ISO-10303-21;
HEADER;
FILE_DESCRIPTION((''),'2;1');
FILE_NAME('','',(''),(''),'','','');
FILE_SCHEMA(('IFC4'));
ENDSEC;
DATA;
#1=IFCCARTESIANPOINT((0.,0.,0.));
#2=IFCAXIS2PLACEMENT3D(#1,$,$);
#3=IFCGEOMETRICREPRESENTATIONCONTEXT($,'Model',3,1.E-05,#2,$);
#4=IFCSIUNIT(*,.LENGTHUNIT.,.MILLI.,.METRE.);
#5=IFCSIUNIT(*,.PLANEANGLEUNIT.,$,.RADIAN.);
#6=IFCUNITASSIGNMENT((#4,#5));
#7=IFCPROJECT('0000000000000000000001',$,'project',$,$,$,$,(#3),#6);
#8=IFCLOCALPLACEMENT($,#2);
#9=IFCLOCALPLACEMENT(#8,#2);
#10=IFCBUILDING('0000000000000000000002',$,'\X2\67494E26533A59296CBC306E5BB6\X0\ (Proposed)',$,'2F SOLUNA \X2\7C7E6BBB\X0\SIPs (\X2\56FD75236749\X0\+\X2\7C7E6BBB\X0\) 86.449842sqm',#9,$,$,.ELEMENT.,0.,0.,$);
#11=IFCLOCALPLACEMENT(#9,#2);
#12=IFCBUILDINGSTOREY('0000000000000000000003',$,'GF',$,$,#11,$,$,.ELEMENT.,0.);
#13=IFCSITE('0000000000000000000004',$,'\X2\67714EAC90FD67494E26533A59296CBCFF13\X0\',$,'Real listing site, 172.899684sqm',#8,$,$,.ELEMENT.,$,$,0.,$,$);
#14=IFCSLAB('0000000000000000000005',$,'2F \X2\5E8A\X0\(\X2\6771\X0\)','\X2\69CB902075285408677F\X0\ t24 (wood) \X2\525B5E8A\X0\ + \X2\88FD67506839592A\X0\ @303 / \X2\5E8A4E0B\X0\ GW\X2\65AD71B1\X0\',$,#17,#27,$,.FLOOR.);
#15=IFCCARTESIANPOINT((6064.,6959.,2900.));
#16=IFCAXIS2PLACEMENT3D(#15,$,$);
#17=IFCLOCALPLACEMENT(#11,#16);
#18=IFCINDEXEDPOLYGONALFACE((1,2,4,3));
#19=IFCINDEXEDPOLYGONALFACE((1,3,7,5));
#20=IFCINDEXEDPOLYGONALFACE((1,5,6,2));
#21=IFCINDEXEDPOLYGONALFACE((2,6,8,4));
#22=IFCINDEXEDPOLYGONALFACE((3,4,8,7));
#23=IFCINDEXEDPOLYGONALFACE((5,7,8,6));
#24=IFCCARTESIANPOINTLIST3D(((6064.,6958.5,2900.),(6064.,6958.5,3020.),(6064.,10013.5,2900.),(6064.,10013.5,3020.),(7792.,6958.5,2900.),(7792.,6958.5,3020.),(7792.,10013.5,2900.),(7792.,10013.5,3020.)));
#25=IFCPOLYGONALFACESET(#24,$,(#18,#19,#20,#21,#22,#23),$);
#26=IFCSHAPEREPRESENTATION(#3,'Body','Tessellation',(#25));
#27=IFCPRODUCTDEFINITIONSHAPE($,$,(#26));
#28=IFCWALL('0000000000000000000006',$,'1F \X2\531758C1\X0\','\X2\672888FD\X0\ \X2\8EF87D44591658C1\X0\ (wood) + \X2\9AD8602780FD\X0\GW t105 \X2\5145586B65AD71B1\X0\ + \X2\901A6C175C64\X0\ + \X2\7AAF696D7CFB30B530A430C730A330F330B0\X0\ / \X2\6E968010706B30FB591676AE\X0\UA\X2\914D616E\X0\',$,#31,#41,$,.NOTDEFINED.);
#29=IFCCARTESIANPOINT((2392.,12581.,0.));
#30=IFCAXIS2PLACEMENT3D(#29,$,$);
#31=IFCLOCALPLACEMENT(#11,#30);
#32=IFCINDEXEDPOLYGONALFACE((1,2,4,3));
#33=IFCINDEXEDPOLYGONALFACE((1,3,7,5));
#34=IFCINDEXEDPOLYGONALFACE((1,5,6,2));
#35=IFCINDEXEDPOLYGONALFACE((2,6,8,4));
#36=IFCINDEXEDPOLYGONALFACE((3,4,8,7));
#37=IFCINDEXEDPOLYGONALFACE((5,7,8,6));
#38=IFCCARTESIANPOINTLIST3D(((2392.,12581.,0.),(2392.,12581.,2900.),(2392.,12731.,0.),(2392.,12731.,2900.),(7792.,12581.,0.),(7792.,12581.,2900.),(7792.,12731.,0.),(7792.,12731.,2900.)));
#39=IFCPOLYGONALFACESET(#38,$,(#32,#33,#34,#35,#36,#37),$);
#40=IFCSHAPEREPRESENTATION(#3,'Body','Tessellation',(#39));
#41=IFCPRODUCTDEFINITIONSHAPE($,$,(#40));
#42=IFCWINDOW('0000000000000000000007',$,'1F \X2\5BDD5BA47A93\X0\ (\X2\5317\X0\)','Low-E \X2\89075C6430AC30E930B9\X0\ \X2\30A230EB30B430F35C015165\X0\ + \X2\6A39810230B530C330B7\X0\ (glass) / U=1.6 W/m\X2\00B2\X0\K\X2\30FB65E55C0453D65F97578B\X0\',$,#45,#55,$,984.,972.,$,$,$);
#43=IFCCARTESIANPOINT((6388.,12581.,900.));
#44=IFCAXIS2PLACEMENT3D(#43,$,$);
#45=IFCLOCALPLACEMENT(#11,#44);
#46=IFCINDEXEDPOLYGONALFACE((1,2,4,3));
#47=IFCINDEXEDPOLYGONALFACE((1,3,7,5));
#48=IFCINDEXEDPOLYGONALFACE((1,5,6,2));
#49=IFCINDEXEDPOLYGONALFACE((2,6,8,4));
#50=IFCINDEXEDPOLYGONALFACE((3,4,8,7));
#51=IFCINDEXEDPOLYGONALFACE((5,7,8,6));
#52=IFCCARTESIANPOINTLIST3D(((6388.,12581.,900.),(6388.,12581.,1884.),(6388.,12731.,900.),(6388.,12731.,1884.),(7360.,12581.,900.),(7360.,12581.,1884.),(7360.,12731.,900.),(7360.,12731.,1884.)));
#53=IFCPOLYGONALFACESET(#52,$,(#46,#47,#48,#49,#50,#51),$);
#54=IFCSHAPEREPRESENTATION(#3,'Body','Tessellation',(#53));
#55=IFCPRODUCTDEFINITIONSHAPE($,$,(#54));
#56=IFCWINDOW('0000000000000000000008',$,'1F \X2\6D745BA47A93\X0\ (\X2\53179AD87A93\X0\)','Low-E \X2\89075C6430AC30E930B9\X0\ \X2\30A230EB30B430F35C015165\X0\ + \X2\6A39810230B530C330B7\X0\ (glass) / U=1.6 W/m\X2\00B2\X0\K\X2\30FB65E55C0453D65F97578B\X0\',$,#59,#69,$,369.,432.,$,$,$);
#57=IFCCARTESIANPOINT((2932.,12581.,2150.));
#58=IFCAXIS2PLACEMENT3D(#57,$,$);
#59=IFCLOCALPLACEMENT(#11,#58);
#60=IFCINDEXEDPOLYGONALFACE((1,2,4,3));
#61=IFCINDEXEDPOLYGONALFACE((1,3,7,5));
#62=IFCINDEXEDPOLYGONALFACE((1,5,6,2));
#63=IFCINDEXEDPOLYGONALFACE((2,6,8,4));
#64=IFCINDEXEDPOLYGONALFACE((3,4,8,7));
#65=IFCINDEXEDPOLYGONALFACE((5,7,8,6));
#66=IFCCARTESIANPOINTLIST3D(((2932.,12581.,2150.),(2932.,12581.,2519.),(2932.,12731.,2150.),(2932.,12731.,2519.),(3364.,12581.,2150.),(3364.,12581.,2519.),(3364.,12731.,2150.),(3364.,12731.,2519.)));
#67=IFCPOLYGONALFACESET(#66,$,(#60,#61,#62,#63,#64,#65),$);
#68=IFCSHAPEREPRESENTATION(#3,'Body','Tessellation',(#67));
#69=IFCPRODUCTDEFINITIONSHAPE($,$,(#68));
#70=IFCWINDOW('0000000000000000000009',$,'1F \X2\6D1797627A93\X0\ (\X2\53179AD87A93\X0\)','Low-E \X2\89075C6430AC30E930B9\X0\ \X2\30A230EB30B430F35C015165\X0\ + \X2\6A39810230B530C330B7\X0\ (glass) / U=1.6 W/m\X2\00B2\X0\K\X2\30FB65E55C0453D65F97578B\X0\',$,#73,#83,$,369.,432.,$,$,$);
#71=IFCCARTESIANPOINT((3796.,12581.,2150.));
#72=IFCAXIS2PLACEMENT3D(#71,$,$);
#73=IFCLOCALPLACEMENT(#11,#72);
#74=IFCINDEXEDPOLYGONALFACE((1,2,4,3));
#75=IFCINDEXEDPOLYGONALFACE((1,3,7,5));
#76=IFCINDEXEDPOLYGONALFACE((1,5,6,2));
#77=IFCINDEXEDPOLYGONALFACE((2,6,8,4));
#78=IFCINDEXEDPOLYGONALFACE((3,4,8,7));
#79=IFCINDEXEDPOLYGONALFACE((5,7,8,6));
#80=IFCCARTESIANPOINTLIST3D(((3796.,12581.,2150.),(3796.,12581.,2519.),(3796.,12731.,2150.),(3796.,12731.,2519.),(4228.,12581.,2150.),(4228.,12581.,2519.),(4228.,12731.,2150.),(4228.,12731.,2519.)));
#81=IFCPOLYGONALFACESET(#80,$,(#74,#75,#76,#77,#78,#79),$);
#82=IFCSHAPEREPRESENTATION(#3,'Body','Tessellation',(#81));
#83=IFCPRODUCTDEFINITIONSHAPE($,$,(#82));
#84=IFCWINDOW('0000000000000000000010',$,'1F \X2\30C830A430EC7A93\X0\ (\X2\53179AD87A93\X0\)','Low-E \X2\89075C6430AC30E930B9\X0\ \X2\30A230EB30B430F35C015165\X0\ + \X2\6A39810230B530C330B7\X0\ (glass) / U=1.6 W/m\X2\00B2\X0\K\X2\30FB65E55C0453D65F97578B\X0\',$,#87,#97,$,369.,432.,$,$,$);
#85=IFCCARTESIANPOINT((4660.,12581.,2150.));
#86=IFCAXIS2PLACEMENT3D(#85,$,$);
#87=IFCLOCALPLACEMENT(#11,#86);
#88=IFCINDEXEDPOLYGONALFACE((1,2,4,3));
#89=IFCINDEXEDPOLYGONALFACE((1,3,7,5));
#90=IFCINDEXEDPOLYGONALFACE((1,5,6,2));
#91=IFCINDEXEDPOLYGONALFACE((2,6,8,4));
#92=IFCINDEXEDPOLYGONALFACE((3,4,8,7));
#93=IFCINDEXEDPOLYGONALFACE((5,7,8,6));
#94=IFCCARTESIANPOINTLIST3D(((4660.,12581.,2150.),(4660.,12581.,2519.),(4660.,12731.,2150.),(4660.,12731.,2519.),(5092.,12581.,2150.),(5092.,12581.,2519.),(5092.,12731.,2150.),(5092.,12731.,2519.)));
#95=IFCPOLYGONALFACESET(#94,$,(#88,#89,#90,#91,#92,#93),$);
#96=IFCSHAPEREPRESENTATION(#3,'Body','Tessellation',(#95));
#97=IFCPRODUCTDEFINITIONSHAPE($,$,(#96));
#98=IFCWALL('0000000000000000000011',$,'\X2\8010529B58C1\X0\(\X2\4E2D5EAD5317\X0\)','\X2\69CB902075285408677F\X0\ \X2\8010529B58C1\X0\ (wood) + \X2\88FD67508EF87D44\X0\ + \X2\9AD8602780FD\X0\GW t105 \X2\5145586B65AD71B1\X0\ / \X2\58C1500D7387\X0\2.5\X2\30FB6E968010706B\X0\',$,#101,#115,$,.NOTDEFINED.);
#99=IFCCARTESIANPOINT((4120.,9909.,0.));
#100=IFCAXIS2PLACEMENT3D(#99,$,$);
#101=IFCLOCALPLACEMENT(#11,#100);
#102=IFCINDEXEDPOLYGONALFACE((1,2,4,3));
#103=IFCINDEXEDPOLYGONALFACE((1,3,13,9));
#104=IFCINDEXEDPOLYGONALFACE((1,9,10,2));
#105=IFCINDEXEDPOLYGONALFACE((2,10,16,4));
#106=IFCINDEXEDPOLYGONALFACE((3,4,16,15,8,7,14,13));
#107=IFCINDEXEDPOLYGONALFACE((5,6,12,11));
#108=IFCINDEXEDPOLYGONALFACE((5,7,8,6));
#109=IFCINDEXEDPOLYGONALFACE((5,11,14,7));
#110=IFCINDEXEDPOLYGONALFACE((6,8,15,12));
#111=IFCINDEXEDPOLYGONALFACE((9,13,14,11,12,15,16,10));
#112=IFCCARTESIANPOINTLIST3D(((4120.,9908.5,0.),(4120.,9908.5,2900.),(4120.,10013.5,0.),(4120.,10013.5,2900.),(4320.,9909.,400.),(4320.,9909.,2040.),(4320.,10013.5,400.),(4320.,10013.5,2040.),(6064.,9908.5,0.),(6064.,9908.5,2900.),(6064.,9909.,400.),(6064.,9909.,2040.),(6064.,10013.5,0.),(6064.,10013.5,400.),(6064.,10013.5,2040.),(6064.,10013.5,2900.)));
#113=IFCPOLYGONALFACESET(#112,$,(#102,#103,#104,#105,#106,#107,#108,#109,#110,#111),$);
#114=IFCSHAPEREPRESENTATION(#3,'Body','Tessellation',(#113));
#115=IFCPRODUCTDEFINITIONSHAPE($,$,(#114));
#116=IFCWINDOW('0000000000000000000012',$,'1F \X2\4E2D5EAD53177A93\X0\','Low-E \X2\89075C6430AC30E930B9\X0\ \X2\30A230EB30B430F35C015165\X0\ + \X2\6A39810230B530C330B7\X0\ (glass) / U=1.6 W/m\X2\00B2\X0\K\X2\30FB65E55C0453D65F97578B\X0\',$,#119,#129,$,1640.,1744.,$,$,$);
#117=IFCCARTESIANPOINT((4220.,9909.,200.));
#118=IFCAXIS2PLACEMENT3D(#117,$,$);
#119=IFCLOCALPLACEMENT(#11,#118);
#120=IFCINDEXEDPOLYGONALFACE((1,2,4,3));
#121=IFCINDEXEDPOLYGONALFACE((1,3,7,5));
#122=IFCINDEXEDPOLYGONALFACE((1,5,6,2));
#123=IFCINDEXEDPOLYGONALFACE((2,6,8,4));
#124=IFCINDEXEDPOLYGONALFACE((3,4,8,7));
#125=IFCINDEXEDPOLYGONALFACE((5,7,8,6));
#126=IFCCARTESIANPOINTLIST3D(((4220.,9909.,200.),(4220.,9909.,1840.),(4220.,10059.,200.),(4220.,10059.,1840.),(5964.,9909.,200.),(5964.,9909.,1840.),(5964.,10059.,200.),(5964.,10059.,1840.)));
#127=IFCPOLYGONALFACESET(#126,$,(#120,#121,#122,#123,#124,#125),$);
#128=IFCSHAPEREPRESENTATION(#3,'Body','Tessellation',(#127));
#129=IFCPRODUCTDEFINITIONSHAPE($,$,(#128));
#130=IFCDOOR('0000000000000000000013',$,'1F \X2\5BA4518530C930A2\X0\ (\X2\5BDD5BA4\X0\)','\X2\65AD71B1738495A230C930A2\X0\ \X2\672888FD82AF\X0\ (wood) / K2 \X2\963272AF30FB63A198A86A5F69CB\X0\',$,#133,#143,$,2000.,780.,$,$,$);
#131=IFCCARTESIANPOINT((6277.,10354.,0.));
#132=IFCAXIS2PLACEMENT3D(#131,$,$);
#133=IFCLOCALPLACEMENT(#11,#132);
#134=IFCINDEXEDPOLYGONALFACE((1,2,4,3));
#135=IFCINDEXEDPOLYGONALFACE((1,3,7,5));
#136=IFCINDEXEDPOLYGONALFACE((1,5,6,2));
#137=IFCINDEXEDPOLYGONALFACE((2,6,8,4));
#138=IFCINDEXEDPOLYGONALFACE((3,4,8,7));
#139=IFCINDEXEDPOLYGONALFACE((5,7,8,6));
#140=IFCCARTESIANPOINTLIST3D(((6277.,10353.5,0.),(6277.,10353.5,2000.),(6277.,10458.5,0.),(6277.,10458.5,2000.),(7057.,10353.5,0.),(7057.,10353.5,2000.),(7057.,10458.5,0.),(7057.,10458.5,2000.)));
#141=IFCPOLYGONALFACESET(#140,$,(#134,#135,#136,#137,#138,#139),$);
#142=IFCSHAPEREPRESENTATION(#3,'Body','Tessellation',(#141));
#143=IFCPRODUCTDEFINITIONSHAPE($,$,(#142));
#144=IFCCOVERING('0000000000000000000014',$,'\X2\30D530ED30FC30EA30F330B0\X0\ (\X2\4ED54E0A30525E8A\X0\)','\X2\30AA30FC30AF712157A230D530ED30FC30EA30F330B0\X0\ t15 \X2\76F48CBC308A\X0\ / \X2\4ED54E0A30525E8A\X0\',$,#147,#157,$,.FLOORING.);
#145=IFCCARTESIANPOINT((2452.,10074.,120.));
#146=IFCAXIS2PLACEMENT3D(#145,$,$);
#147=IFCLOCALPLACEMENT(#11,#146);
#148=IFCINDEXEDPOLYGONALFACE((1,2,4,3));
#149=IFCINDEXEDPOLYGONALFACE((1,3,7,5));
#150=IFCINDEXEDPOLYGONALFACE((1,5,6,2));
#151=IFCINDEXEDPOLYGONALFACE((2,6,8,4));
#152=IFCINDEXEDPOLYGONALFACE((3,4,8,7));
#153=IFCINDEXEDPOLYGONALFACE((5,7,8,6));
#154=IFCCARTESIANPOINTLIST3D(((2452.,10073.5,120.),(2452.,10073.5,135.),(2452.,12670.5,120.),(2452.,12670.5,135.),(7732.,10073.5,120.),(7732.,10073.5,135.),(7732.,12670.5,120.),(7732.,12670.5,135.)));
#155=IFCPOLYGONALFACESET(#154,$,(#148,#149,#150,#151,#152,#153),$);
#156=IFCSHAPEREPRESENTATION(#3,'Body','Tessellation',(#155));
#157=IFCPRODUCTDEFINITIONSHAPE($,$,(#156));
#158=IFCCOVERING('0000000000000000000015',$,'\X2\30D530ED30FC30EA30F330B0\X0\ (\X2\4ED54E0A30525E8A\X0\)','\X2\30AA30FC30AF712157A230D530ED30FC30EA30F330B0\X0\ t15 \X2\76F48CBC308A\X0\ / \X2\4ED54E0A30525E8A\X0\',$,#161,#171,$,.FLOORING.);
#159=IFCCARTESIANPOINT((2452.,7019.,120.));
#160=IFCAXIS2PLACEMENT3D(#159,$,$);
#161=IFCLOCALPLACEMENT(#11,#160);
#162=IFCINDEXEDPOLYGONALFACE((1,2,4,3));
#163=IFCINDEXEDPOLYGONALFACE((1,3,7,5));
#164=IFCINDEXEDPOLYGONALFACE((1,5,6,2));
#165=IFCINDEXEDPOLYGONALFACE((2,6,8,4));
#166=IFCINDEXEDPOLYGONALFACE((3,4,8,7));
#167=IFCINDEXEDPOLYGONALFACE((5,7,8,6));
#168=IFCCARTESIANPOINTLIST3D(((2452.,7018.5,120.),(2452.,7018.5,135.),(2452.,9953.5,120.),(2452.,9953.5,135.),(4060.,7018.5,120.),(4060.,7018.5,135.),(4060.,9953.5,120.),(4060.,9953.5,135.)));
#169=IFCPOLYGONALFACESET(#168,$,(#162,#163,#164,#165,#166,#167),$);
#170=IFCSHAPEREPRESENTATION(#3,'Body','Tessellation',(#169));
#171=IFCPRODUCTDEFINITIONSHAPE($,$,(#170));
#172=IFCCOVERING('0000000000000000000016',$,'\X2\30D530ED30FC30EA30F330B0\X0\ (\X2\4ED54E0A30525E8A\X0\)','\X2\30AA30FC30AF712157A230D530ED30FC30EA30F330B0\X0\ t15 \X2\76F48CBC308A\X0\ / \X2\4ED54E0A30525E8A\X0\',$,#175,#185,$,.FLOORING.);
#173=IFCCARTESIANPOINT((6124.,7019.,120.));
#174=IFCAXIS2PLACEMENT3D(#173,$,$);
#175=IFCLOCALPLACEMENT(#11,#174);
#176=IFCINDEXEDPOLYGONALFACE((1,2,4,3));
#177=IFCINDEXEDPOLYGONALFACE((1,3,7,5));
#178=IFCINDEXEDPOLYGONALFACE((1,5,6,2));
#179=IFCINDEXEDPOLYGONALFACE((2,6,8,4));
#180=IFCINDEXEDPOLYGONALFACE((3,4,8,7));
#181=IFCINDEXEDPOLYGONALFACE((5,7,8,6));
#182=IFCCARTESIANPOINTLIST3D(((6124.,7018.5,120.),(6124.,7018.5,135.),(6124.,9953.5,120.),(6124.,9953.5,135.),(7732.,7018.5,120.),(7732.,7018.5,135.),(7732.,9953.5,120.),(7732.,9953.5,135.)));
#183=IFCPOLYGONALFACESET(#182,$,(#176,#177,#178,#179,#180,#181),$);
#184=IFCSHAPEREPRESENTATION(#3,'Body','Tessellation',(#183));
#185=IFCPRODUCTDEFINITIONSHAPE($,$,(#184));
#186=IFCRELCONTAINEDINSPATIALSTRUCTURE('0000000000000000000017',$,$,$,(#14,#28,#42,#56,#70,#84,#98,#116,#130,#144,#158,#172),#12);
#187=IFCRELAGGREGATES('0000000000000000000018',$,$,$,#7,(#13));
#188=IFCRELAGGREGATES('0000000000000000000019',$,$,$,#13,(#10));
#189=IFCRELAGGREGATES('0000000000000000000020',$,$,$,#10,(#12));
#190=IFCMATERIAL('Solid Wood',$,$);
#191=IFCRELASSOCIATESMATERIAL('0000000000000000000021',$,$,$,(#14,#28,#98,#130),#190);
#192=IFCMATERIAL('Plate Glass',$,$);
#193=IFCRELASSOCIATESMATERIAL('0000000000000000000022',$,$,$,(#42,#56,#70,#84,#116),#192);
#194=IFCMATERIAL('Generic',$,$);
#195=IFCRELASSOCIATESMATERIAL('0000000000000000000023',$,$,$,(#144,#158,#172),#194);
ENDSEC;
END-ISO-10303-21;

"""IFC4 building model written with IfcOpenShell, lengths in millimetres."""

from ifc_helpers import new_model, si_unit, frame, frame_2d, origin, place, context, project, spatial, rectangle, extrude, material, element, fill, save


model = new_model("IFC4")

# Units and contexts
model_context = context("Model", 3, precision=1e-05, world=origin())
ifc_project = project(units=[si_unit("LENGTHUNIT", "METRE", prefix="MILLI"), si_unit("PLANEANGLEUNIT", "RADIAN")], contexts=[model_context])

# Site, building, storey
site_placement = place(None, origin())
site = spatial("IfcSite", under=ifc_project, at=site_placement, Name="東京都杉並区天沼３", ObjectType="Real listing site, 172.899684sqm", CompositionType="ELEMENT", RefElevation=0.0)
building_placement = place(site_placement, origin())
building = spatial("IfcBuilding", under=site, at=building_placement, Name="杉並区天沼の家 (Proposed)", ObjectType="2F SOLUNA 籾殻SIPs (国産杉+籾殻) 86.449842sqm", CompositionType="ELEMENT", ElevationOfRefHeight=0.0, ElevationOfTerrain=0.0)
storey_placement = place(building_placement, origin())
storey = spatial("IfcBuildingStorey", under=building, at=storey_placement, Name="GF", CompositionType="ELEMENT", Elevation=0.0)

# Slab
ifc_material_1 = material(Name="Solid Wood")
slab_1_placement = place(storey_placement, frame((6064.0, 6959.0, 2900.0)))
element("IfcSlab", 1, at=slab_1_placement, inside=storey, material=ifc_material_1, Name="2F 床(東)", Description="構造用合板 t24 (wood) 剛床 + 製材根太 @303 / 床下 GW断熱", PredefinedType="FLOOR", context=model_context, shape_type="SweptSolid", body=[
    extrude(rectangle(XDim=1728.0, YDim=3055.0, at=frame_2d((864.0, 1527.0))), frame((6064.0, 6959.0, 2900.0)), (0.0, 0.0, 1.0), 120.0),
])

# Wall, openings, windows
wall_1_placement = place(storey_placement, frame((2392.0, 12581.0, 0.0)))
wall_1 = element("IfcWall", 2, at=wall_1_placement, inside=storey, material=ifc_material_1, Name="1F 北壁", Description="木製 軸組外壁 (wood) + 高性能GW t105 充填断熱 + 通気層 + 窯業系サイディング / 準耐火・外皮UA配慮", PredefinedType="NOTDEFINED", context=model_context, shape_type="SweptSolid", body=[
    extrude(rectangle(XDim=5400.0, YDim=150.0, at=frame_2d((2700.0, 75.0))), frame((2392.0, 12581.0, 0.0)), (0.0, 0.0, 1.0), 2900.0),
])
opening_1_placement = place(storey_placement, frame((6388.0, 12581.0, 900.0)))
opening_1 = element("IfcOpeningElement", 3, at=opening_1_placement, cuts=wall_1, PredefinedType="NOTDEFINED", context=model_context, shape_type="SweptSolid", body=[
    extrude(rectangle(XDim=972.0, YDim=150.0, at=frame_2d((486.0, 75.0))), frame((6388.0, 12581.0, 900.0)), (0.0, 0.0, 1.0), 984.0),
])
opening_2_placement = place(storey_placement, frame((2932.0, 12581.0, 2150.0)))
opening_2 = element("IfcOpeningElement", 4, at=opening_2_placement, cuts=wall_1, PredefinedType="NOTDEFINED", context=model_context, shape_type="SweptSolid", body=[
    extrude(rectangle(XDim=432.0, YDim=150.0, at=frame_2d((216.0, 75.0))), frame((2932.0, 12581.0, 2150.0)), (0.0, 0.0, 1.0), 369.0),
])
opening_3_placement = place(storey_placement, frame((3796.0, 12581.0, 2150.0)))
opening_3 = element("IfcOpeningElement", 5, at=opening_3_placement, cuts=wall_1, PredefinedType="NOTDEFINED", context=model_context, shape_type="SweptSolid", body=[
    extrude(rectangle(XDim=432.0, YDim=150.0, at=frame_2d((216.0, 75.0))), frame((3796.0, 12581.0, 2150.0)), (0.0, 0.0, 1.0), 369.0),
])
opening_4_placement = place(storey_placement, frame((4660.0, 12581.0, 2150.0)))
opening_4 = element("IfcOpeningElement", 6, at=opening_4_placement, cuts=wall_1, PredefinedType="NOTDEFINED", context=model_context, shape_type="SweptSolid", body=[
    extrude(rectangle(XDim=432.0, YDim=150.0, at=frame_2d((216.0, 75.0))), frame((4660.0, 12581.0, 2150.0)), (0.0, 0.0, 1.0), 369.0),
])
ifc_material_2 = material(Name="Plate Glass")
window_1_placement = place(storey_placement, frame((6388.0, 12581.0, 900.0)))
window_1 = element("IfcWindow", 7, at=window_1_placement, inside=storey, material=ifc_material_2, Name="1F 寝室窓 (北)", Description="Low-E 複層ガラス アルゴン封入 + 樹脂サッシ (glass) / U=1.6 W/m²K・日射取得型", OverallHeight=984.0, OverallWidth=972.0, context=model_context, shape_type="SweptSolid", body=[
    extrude(rectangle(XDim=972.0, YDim=150.0, at=frame_2d((486.0, 75.0))), frame((6388.0, 12581.0, 900.0)), (0.0, 0.0, 1.0), 984.0),
])
fill(opening_1, window_1)
window_2_placement = place(storey_placement, frame((2932.0, 12581.0, 2150.0)))
window_2 = element("IfcWindow", 8, at=window_2_placement, inside=storey, material=ifc_material_2, Name="1F 浴室窓 (北高窓)", Description="Low-E 複層ガラス アルゴン封入 + 樹脂サッシ (glass) / U=1.6 W/m²K・日射取得型", OverallHeight=369.0, OverallWidth=432.0, context=model_context, shape_type="SweptSolid", body=[
    extrude(rectangle(XDim=432.0, YDim=150.0, at=frame_2d((216.0, 75.0))), frame((2932.0, 12581.0, 2150.0)), (0.0, 0.0, 1.0), 369.0),
])
fill(opening_2, window_2)
window_3_placement = place(storey_placement, frame((3796.0, 12581.0, 2150.0)))
window_3 = element("IfcWindow", 9, at=window_3_placement, inside=storey, material=ifc_material_2, Name="1F 洗面窓 (北高窓)", Description="Low-E 複層ガラス アルゴン封入 + 樹脂サッシ (glass) / U=1.6 W/m²K・日射取得型", OverallHeight=369.0, OverallWidth=432.0, context=model_context, shape_type="SweptSolid", body=[
    extrude(rectangle(XDim=432.0, YDim=150.0, at=frame_2d((216.0, 75.0))), frame((3796.0, 12581.0, 2150.0)), (0.0, 0.0, 1.0), 369.0),
])
fill(opening_3, window_3)
window_4_placement = place(storey_placement, frame((4660.0, 12581.0, 2150.0)))
window_4 = element("IfcWindow", 10, at=window_4_placement, inside=storey, material=ifc_material_2, Name="1F トイレ窓 (北高窓)", Description="Low-E 複層ガラス アルゴン封入 + 樹脂サッシ (glass) / U=1.6 W/m²K・日射取得型", OverallHeight=369.0, OverallWidth=432.0, context=model_context, shape_type="SweptSolid", body=[
    extrude(rectangle(XDim=432.0, YDim=150.0, at=frame_2d((216.0, 75.0))), frame((4660.0, 12581.0, 2150.0)), (0.0, 0.0, 1.0), 369.0),
])
fill(opening_4, window_4)

# Wall, opening, window
wall_2_placement = place(storey_placement, frame((4120.0, 9909.0, 0.0)))
wall_2 = element("IfcWall", 11, at=wall_2_placement, inside=storey, material=ifc_material_1, Name="耐力壁(中庭北)", Description="構造用合板 耐力壁 (wood) + 製材軸組 + 高性能GW t105 充填断熱 / 壁倍率2.5・準耐火", PredefinedType="NOTDEFINED", context=model_context, shape_type="SweptSolid", body=[
    extrude(rectangle(XDim=1944.0, YDim=105.0, at=frame_2d((972.0, 52.0))), frame((4120.0, 9909.0, 0.0)), (0.0, 0.0, 1.0), 2900.0),
])
opening_5_placement = place(storey_placement, frame((4220.0, 9909.0, 200.0)))
opening_5 = element("IfcOpeningElement", 12, at=opening_5_placement, cuts=wall_2, PredefinedType="NOTDEFINED", context=model_context, shape_type="SweptSolid", body=[
    extrude(rectangle(XDim=1744.0, YDim=150.0, at=frame_2d((872.0, 75.0))), frame((4220.0, 9909.0, 200.0)), (0.0, 0.0, 1.0), 1640.0),
])
window_5_placement = place(storey_placement, frame((4220.0, 9909.0, 200.0)))
window_5 = element("IfcWindow", 13, at=window_5_placement, inside=storey, material=ifc_material_2, Name="1F 中庭北窓", Description="Low-E 複層ガラス アルゴン封入 + 樹脂サッシ (glass) / U=1.6 W/m²K・日射取得型", OverallHeight=1640.0, OverallWidth=1744.0, context=model_context, shape_type="SweptSolid", body=[
    extrude(rectangle(XDim=1744.0, YDim=150.0, at=frame_2d((872.0, 75.0))), frame((4220.0, 9909.0, 200.0)), (0.0, 0.0, 1.0), 1640.0),
])
fill(opening_5, window_5)

# Door
door_1_placement = place(storey_placement, frame((6277.0, 10354.0, 0.0)))
element("IfcDoor", 14, at=door_1_placement, inside=storey, material=ifc_material_1, Name="1F 室内ドア (寝室)", Description="断熱玄関ドア 木製芯 (wood) / K2 防犯・採風機構", OverallHeight=2000.0, OverallWidth=780.0, context=model_context, shape_type="SweptSolid", body=[
    extrude(rectangle(XDim=780.0, YDim=105.0, at=frame_2d((390.0, 52.0))), frame((6277.0, 10354.0, 0.0)), (0.0, 0.0, 1.0), 2000.0),
])

# Coverings
ifc_material_3 = material(Name="Generic")
covering_1_placement = place(storey_placement, frame((2452.0, 10074.0, 120.0)))
element("IfcCovering", 15, at=covering_1_placement, inside=storey, material=ifc_material_3, Name="フローリング (仕上げ床)", Description="オーク無垢フローリング t15 直貼り / 仕上げ床", PredefinedType="FLOORING", context=model_context, shape_type="SweptSolid", body=[
    extrude(rectangle(XDim=5280.0, YDim=2597.0, at=frame_2d((2640.0, 1298.0))), frame((2452.0, 10074.0, 120.0)), (0.0, 0.0, 1.0), 15.0),
])
covering_2_placement = place(storey_placement, frame((2452.0, 7019.0, 120.0)))
element("IfcCovering", 16, at=covering_2_placement, inside=storey, material=ifc_material_3, Name="フローリング (仕上げ床)", Description="オーク無垢フローリング t15 直貼り / 仕上げ床", PredefinedType="FLOORING", context=model_context, shape_type="SweptSolid", body=[
    extrude(rectangle(XDim=1608.0, YDim=2935.0, at=frame_2d((804.0, 1467.0))), frame((2452.0, 7019.0, 120.0)), (0.0, 0.0, 1.0), 15.0),
])
covering_3_placement = place(storey_placement, frame((6124.0, 7019.0, 120.0)))
element("IfcCovering", 17, at=covering_3_placement, inside=storey, material=ifc_material_3, Name="フローリング (仕上げ床)", Description="オーク無垢フローリング t15 直貼り / 仕上げ床", PredefinedType="FLOORING", context=model_context, shape_type="SweptSolid", body=[
    extrude(rectangle(XDim=1608.0, YDim=2935.0, at=frame_2d((804.0, 1467.0))), frame((6124.0, 7019.0, 120.0)), (0.0, 0.0, 1.0), 15.0),
])

save(model, "model.ifc")
